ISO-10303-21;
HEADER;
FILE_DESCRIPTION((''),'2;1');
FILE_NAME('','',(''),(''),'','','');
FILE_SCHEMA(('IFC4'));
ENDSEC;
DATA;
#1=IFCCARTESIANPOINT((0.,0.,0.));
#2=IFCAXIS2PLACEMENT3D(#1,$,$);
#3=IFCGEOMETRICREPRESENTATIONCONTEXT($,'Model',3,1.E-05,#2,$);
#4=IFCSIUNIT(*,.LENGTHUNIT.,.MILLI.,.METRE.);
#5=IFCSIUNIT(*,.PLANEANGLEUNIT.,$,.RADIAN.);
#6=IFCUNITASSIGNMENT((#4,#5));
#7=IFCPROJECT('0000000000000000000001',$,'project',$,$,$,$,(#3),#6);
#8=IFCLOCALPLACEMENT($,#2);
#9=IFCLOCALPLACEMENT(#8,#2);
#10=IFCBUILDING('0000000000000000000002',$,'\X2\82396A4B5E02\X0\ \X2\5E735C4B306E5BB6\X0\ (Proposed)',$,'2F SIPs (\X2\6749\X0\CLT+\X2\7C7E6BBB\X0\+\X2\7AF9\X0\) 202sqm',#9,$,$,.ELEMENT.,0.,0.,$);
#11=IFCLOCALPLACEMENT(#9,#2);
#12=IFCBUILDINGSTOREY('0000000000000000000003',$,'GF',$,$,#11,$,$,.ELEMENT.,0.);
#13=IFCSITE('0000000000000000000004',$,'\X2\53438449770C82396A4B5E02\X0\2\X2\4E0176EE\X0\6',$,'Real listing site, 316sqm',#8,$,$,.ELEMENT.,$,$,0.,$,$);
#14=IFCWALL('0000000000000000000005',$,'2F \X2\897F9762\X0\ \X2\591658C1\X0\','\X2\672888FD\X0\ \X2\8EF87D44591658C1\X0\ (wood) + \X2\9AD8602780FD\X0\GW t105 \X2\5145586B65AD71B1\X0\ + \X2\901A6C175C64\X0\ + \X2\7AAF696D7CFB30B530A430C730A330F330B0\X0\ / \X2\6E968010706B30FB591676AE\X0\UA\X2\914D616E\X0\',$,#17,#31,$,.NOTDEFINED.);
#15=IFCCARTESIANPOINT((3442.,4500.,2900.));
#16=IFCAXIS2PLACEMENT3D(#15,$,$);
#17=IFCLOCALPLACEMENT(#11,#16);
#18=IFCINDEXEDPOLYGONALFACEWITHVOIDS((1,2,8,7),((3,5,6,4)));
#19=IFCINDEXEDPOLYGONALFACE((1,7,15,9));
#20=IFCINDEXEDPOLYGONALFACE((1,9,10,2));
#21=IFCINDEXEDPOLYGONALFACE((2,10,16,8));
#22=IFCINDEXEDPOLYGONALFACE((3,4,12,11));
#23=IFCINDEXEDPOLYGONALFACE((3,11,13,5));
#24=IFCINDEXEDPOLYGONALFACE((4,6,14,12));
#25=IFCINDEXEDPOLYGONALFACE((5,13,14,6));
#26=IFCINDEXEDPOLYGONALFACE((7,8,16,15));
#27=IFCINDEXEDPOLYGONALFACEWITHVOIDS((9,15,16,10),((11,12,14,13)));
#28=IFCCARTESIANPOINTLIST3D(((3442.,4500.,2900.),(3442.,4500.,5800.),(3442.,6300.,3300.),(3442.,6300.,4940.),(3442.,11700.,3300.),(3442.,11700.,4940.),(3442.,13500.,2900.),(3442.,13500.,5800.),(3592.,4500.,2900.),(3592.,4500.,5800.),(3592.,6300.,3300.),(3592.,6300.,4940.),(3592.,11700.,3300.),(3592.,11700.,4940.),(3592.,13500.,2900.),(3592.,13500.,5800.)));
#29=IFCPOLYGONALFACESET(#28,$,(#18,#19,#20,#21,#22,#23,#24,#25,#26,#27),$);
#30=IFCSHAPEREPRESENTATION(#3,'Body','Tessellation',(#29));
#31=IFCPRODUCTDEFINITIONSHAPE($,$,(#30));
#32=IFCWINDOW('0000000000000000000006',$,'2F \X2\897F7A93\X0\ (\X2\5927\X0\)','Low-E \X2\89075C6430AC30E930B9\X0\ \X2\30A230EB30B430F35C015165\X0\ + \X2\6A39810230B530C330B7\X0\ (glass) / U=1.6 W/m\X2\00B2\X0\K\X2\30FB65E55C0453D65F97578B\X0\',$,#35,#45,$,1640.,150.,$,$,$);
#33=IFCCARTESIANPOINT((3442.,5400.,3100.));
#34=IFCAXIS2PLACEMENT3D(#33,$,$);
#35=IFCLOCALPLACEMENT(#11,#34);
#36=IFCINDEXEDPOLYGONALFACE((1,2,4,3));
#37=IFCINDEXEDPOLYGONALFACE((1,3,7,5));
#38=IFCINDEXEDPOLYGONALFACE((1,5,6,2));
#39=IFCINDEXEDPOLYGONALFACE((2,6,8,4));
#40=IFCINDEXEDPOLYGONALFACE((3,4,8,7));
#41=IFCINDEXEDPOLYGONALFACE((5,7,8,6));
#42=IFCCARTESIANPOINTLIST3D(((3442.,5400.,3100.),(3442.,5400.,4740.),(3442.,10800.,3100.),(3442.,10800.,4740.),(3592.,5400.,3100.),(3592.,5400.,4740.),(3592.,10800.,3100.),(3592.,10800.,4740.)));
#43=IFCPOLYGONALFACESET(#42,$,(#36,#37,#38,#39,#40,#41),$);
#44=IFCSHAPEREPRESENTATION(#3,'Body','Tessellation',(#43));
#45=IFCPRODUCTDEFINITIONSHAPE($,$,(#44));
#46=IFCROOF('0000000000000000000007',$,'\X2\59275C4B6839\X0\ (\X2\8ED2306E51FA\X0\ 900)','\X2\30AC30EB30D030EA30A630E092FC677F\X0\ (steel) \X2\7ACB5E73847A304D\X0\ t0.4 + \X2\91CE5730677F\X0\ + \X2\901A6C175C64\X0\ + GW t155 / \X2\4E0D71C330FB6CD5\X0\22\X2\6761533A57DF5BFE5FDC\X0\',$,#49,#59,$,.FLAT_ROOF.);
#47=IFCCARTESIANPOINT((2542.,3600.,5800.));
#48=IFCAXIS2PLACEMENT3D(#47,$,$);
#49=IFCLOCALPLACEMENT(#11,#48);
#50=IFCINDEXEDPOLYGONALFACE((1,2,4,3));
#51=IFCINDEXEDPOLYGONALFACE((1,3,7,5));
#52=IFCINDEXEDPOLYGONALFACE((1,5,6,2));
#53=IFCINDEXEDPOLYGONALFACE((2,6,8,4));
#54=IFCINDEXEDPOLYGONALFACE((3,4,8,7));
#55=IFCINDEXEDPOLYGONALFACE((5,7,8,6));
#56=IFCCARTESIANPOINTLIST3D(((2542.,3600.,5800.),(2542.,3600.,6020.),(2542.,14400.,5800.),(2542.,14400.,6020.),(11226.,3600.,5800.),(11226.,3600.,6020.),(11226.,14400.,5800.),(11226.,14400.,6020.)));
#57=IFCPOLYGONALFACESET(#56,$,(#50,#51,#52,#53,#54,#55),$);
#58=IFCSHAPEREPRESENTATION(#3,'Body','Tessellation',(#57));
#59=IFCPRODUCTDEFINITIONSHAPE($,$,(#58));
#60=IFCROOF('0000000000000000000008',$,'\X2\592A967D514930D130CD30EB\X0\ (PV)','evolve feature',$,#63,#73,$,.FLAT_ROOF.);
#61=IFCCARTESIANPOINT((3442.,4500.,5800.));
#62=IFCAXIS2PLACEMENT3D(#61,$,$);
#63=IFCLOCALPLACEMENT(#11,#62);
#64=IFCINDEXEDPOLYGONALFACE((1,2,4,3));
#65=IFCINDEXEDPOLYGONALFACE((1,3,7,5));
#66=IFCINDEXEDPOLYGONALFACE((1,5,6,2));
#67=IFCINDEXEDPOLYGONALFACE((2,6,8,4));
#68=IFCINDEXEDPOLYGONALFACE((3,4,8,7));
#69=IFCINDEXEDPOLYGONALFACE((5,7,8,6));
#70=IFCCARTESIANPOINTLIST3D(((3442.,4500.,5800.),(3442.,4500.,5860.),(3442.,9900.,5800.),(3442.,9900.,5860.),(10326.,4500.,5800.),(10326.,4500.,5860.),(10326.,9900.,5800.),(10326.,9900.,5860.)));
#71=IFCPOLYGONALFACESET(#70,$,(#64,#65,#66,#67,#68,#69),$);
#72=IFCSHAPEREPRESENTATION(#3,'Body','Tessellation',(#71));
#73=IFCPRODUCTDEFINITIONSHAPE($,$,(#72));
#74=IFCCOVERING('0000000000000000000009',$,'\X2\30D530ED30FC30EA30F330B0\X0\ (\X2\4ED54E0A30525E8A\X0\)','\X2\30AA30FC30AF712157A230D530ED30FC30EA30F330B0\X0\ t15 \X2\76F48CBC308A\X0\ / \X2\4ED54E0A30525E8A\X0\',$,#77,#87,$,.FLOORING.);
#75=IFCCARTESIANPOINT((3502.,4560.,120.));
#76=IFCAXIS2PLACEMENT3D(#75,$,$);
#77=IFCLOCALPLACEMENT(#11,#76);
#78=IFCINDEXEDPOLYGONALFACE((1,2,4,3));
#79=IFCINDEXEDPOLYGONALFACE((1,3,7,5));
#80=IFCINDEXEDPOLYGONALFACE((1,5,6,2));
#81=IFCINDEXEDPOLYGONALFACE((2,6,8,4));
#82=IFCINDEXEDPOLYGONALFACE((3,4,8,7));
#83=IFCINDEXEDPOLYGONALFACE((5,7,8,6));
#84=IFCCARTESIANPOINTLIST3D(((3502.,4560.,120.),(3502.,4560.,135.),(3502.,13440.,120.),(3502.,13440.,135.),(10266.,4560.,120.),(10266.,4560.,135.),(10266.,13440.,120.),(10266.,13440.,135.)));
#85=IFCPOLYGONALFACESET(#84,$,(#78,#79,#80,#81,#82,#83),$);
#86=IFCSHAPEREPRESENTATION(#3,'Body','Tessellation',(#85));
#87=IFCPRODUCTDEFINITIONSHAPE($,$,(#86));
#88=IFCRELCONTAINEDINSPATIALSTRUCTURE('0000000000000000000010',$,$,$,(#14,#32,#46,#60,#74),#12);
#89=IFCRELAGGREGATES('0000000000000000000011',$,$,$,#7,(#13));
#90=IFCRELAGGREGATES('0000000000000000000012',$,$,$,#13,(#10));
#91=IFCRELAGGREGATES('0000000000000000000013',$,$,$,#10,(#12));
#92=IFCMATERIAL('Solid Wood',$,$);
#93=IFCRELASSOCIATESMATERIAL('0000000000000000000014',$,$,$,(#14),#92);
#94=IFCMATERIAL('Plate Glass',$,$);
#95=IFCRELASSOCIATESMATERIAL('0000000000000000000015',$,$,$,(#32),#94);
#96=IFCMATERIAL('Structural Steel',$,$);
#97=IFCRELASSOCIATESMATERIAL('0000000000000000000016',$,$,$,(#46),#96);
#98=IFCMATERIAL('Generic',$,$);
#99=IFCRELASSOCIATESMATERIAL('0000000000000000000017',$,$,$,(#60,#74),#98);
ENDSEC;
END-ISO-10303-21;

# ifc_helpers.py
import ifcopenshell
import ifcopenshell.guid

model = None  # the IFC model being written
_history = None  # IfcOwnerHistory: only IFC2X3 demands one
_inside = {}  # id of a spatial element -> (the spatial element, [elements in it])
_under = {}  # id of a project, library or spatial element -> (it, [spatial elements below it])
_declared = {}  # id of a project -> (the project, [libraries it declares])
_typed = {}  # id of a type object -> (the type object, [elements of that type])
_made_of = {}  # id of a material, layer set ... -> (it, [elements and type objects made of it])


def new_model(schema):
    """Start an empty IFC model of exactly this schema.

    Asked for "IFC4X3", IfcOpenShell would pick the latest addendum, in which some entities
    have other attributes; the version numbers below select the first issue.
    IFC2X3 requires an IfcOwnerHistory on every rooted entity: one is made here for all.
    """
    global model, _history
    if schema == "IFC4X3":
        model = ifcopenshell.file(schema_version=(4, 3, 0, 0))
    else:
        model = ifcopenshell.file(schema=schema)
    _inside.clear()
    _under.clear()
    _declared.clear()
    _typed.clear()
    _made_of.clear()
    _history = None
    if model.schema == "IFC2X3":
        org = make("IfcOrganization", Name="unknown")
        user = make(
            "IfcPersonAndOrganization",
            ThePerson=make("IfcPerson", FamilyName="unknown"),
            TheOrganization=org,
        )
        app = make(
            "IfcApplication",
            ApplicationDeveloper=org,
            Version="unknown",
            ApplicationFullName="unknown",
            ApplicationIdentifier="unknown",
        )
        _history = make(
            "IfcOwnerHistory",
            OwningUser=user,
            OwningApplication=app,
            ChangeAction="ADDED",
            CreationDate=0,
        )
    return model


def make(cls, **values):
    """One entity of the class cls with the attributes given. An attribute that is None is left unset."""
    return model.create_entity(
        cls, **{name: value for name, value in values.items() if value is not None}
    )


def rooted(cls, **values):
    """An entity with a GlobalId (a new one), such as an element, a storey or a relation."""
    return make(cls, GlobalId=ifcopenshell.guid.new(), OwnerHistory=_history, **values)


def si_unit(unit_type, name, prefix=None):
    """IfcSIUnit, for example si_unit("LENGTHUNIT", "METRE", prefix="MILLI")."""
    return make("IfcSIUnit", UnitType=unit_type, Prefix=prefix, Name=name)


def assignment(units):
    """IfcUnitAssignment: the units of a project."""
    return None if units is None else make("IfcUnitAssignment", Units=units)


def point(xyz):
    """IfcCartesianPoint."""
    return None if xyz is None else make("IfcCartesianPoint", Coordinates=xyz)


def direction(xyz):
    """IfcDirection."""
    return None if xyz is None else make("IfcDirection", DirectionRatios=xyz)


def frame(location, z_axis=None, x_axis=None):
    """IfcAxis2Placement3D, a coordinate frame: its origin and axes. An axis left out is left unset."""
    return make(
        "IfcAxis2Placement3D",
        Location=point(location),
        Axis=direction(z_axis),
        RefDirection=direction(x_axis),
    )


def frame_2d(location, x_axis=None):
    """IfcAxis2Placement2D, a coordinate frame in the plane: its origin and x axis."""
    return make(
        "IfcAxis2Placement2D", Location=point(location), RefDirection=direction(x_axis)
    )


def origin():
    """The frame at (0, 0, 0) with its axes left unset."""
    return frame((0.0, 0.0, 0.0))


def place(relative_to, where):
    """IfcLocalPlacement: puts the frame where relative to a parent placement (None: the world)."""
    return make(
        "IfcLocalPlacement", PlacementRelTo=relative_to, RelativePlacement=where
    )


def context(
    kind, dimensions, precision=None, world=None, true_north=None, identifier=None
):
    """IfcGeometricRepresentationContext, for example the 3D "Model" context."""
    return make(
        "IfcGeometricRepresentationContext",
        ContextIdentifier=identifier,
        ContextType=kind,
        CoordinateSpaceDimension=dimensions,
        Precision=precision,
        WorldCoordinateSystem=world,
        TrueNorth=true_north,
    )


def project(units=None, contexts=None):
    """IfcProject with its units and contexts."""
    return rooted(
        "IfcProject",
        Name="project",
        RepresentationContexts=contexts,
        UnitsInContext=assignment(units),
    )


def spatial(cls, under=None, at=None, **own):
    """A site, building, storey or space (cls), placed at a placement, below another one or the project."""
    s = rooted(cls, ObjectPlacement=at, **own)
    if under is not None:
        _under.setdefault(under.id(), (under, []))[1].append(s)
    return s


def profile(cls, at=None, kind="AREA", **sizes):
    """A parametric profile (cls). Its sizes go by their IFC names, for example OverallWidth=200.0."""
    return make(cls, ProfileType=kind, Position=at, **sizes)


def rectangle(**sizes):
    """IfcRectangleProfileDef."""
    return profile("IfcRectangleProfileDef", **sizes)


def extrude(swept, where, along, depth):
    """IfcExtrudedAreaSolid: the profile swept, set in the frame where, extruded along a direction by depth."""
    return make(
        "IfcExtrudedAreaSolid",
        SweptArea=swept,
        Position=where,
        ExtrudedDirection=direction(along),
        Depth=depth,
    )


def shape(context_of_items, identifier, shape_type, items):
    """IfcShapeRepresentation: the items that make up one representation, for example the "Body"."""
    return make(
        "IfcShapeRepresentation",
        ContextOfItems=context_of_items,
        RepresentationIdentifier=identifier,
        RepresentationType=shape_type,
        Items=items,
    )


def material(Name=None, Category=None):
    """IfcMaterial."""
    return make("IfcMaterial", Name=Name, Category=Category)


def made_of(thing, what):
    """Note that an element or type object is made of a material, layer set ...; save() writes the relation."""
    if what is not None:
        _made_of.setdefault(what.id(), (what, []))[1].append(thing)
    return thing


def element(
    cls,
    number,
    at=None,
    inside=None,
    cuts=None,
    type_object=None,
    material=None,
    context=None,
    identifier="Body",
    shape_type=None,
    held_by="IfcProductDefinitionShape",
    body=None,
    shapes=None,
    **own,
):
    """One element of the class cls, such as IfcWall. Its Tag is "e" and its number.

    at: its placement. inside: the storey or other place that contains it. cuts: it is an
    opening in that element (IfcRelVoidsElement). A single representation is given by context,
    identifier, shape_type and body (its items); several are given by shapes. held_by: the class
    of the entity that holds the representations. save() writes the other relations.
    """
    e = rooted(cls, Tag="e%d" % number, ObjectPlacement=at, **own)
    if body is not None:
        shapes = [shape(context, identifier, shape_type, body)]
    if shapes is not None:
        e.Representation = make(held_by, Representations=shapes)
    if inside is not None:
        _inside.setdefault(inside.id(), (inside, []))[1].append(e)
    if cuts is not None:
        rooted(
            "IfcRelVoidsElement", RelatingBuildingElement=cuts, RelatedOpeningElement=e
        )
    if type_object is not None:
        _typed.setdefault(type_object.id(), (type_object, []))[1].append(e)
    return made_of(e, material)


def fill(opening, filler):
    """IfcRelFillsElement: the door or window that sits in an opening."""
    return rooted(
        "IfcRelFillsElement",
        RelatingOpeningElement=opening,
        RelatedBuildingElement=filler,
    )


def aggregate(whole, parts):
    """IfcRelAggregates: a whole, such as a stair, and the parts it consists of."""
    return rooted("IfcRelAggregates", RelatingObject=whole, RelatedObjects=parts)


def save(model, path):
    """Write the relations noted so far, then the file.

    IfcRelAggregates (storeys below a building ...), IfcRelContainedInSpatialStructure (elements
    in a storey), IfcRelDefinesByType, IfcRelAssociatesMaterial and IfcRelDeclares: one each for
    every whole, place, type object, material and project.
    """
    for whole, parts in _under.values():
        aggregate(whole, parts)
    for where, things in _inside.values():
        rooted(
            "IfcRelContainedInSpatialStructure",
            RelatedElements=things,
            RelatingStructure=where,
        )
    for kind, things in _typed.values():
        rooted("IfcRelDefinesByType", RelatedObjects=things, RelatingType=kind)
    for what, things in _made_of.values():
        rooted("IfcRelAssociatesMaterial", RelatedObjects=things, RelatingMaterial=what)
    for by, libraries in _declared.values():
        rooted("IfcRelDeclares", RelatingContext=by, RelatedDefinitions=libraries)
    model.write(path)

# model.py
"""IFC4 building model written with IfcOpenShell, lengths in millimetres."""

from ifc_helpers import new_model, si_unit, frame, frame_2d, origin, place, context, project, spatial, rectangle, extrude, material, element, fill, save


model = new_model("IFC4")

# Units and contexts
model_context = context("Model", 3, precision=1e-05, world=origin())
ifc_project = project(units=[si_unit("LENGTHUNIT", "METRE", prefix="MILLI"), si_unit("PLANEANGLEUNIT", "RADIAN")], contexts=[model_context])

# Site, building, storey
site_placement = place(None, origin())
site = spatial("IfcSite", under=ifc_project, at=site_placement, Name="千葉県船橋市2丁目6", ObjectType="Real listing site, 316sqm", CompositionType="ELEMENT", RefElevation=0.0)
building_placement = place(site_placement, origin())
building = spatial("IfcBuilding", under=site, at=building_placement, Name="船橋市 平屋の家 (Proposed)", ObjectType="2F SIPs (杉CLT+籾殻+竹) 202sqm", CompositionType="ELEMENT", ElevationOfRefHeight=0.0, ElevationOfTerrain=0.0)
storey_placement = place(building_placement, origin())
storey = spatial("IfcBuildingStorey", under=building, at=storey_placement, Name="GF", CompositionType="ELEMENT", Elevation=0.0)

# Shared definitions
ifc_material_1 = material(Name="Solid Wood")

# Shared definitions
ifc_material_2 = material(Name="Plate Glass")
ifc_material_3 = material(Name="Generic")

# Wall, opening, window
wall_1_placement = place(storey_placement, frame((3442.0, 4500.0, 2900.0)))
wall_1 = element("IfcWall", 1, at=wall_1_placement, inside=storey, material=ifc_material_1, Name="2F 西面 外壁", Description="木製 軸組外壁 (wood) + 高性能GW t105 充填断熱 + 通気層 + 窯業系サイディング / 準耐火・外皮UA配慮", PredefinedType="NOTDEFINED", context=model_context, shape_type="SweptSolid", body=[
    extrude(rectangle(XDim=150.0, YDim=9000.0, at=frame_2d((75.0, 4500.0))), frame((3442.0, 4500.0, 2900.0)), (0.0, 0.0, 1.0), 2900.0),
])
opening_1_placement = place(storey_placement, frame((3442.0, 5400.0, 3100.0)))
opening_1 = element("IfcOpeningElement", 2, at=opening_1_placement, cuts=wall_1, PredefinedType="NOTDEFINED", context=model_context, shape_type="SweptSolid", body=[
    extrude(rectangle(XDim=150.0, YDim=5400.0, at=frame_2d((75.0, 2700.0))), frame((3442.0, 5400.0, 3100.0)), (0.0, 0.0, 1.0), 1640.0),
])
window_1_placement = place(storey_placement, frame((3442.0, 5400.0, 3100.0)))
window_1 = element("IfcWindow", 3, at=window_1_placement, inside=storey, material=ifc_material_2, Name="2F 西窓 (大)", Description="Low-E 複層ガラス アルゴン封入 + 樹脂サッシ (glass) / U=1.6 W/m²K・日射取得型", OverallHeight=1640.0, OverallWidth=150.0, context=model_context, shape_type="SweptSolid", body=[
    extrude(rectangle(XDim=150.0, YDim=5400.0, at=frame_2d((75.0, 2700.0))), frame((3442.0, 5400.0, 3100.0)), (0.0, 0.0, 1.0), 1640.0),
])
fill(opening_1, window_1)

# Roofs
ifc_material_4 = material(Name="Structural Steel")
roof_1_placement = place(storey_placement, frame((2542.0, 3600.0, 5800.0)))
element("IfcRoof", 4, at=roof_1_placement, inside=storey, material=ifc_material_4, Name="大屋根 (軒の出 900)", Description="ガルバリウム鋼板 (steel) 立平葺き t0.4 + 野地板 + 通気層 + GW t155 / 不燃・法22条区域対応", PredefinedType="FLAT_ROOF", context=model_context, shape_type="SweptSolid", body=[
    extrude(rectangle(XDim=8684.0, YDim=10800.0, at=frame_2d((4342.0, 5400.0))), frame((2542.0, 3600.0, 5800.0)), (0.0, 0.0, 1.0), 220.0),
])
roof_2_placement = place(storey_placement, frame((3442.0, 4500.0, 5800.0)))
element("IfcRoof", 5, at=roof_2_placement, inside=storey, material=ifc_material_3, Name="太陽光パネル (PV)", Description="evolve feature", PredefinedType="FLAT_ROOF", context=model_context, shape_type="SweptSolid", body=[
    extrude(rectangle(XDim=6884.0, YDim=5400.0, at=frame_2d((3442.0, 2700.0))), frame((3442.0, 4500.0, 5800.0)), (0.0, 0.0, 1.0), 60.0),
])

# Covering
covering_placement = place(storey_placement, frame((3502.0, 4560.0, 120.0)))
element("IfcCovering", 6, at=covering_placement, inside=storey, material=ifc_material_3, Name="フローリング (仕上げ床)", Description="オーク無垢フローリング t15 直貼り / 仕上げ床", PredefinedType="FLOORING", context=model_context, shape_type="SweptSolid", body=[
    extrude(rectangle(XDim=6764.0, YDim=8880.0, at=frame_2d((3382.0, 4440.0))), frame((3502.0, 4560.0, 120.0)), (0.0, 0.0, 1.0), 15.0),
])

save(model, "model.ifc")
